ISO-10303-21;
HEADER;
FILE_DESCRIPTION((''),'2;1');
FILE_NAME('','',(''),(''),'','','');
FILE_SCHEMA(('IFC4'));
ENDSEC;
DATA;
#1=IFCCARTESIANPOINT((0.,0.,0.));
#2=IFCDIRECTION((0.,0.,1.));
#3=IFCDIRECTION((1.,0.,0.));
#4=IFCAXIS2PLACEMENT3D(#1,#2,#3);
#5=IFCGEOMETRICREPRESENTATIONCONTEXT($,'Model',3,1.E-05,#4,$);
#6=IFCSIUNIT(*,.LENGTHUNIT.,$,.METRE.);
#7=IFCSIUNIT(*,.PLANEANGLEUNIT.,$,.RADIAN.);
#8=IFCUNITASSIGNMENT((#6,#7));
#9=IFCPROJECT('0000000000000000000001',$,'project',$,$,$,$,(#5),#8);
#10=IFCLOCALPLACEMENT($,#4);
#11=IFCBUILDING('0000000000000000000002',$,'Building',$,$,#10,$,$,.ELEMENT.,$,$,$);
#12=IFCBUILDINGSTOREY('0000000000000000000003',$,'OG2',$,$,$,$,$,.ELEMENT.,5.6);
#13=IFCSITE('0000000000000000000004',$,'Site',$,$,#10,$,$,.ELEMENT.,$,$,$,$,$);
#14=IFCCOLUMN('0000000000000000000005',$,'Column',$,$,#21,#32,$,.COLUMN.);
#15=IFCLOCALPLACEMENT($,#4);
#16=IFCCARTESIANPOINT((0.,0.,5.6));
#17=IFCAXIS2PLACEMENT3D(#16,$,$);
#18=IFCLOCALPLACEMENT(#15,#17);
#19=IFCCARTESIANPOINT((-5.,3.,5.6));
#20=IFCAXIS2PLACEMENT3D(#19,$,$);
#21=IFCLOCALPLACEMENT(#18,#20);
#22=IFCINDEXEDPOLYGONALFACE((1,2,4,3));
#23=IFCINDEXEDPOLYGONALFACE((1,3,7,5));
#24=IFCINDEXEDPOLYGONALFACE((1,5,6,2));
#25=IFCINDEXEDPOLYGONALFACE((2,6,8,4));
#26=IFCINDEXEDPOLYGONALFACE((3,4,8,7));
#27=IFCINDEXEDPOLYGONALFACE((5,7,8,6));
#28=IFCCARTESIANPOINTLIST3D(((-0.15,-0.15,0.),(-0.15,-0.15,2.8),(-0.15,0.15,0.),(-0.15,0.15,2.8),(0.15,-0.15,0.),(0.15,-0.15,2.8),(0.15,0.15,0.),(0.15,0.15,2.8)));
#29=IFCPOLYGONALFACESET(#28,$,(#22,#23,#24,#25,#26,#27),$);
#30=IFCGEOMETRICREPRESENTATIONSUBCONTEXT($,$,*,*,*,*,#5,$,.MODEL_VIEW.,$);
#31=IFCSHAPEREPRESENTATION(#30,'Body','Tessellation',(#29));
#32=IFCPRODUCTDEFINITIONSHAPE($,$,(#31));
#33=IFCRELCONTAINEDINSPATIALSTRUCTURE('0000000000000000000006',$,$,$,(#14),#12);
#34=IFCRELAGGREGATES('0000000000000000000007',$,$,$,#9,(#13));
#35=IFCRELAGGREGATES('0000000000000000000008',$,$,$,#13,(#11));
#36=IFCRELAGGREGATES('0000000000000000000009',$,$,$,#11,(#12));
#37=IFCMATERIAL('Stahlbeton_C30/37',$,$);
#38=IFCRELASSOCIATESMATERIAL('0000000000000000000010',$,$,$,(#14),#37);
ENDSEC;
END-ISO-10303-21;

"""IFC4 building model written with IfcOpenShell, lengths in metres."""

from ifc_helpers import new_model, si_unit, frame, origin, origin_with_axes, origin_2d, place, context, subcontext, project, spatial, rectangle, extrude, material, element, save


model = new_model("IFC4")

# Units and contexts
model_context = context("Model", 3, precision=1e-05, world=origin_with_axes())
sub_context = subcontext(model_context, None, None, "MODEL_VIEW")
ifc_project = project(units=[si_unit("LENGTHUNIT", "METRE"), si_unit("PLANEANGLEUNIT", "RADIAN")], contexts=[model_context])

# Site, building, storey
placement_1 = place(None, origin_with_axes())
site = spatial("IfcSite", under=ifc_project, at=placement_1, Name="Site", CompositionType="ELEMENT")
building = spatial("IfcBuilding", under=site, at=placement_1, Name="Building", CompositionType="ELEMENT")
storey = spatial("IfcBuildingStorey", under=building, Name="OG2", CompositionType="ELEMENT", Elevation=5.6)

# Column
ifc_material = material(Name="Stahlbeton_C30/37")
placement_2 = place(None, origin_with_axes())
placement_3 = place(placement_2, frame((0.0, 0.0, 5.6)))
column_placement = place(placement_3, frame((-5.0, 3.0, 5.6)))
element("IfcColumn", 1, at=column_placement, inside=storey, material=ifc_material, Name="Column", PredefinedType="COLUMN", context=sub_context, shape_type="SweptSolid", body=[
    extrude(rectangle(XDim=0.3, YDim=0.3, at=origin_2d()), origin(), (0.0, 0.0, 1.0), 2.8),
])

save(model, "model.ifc")
